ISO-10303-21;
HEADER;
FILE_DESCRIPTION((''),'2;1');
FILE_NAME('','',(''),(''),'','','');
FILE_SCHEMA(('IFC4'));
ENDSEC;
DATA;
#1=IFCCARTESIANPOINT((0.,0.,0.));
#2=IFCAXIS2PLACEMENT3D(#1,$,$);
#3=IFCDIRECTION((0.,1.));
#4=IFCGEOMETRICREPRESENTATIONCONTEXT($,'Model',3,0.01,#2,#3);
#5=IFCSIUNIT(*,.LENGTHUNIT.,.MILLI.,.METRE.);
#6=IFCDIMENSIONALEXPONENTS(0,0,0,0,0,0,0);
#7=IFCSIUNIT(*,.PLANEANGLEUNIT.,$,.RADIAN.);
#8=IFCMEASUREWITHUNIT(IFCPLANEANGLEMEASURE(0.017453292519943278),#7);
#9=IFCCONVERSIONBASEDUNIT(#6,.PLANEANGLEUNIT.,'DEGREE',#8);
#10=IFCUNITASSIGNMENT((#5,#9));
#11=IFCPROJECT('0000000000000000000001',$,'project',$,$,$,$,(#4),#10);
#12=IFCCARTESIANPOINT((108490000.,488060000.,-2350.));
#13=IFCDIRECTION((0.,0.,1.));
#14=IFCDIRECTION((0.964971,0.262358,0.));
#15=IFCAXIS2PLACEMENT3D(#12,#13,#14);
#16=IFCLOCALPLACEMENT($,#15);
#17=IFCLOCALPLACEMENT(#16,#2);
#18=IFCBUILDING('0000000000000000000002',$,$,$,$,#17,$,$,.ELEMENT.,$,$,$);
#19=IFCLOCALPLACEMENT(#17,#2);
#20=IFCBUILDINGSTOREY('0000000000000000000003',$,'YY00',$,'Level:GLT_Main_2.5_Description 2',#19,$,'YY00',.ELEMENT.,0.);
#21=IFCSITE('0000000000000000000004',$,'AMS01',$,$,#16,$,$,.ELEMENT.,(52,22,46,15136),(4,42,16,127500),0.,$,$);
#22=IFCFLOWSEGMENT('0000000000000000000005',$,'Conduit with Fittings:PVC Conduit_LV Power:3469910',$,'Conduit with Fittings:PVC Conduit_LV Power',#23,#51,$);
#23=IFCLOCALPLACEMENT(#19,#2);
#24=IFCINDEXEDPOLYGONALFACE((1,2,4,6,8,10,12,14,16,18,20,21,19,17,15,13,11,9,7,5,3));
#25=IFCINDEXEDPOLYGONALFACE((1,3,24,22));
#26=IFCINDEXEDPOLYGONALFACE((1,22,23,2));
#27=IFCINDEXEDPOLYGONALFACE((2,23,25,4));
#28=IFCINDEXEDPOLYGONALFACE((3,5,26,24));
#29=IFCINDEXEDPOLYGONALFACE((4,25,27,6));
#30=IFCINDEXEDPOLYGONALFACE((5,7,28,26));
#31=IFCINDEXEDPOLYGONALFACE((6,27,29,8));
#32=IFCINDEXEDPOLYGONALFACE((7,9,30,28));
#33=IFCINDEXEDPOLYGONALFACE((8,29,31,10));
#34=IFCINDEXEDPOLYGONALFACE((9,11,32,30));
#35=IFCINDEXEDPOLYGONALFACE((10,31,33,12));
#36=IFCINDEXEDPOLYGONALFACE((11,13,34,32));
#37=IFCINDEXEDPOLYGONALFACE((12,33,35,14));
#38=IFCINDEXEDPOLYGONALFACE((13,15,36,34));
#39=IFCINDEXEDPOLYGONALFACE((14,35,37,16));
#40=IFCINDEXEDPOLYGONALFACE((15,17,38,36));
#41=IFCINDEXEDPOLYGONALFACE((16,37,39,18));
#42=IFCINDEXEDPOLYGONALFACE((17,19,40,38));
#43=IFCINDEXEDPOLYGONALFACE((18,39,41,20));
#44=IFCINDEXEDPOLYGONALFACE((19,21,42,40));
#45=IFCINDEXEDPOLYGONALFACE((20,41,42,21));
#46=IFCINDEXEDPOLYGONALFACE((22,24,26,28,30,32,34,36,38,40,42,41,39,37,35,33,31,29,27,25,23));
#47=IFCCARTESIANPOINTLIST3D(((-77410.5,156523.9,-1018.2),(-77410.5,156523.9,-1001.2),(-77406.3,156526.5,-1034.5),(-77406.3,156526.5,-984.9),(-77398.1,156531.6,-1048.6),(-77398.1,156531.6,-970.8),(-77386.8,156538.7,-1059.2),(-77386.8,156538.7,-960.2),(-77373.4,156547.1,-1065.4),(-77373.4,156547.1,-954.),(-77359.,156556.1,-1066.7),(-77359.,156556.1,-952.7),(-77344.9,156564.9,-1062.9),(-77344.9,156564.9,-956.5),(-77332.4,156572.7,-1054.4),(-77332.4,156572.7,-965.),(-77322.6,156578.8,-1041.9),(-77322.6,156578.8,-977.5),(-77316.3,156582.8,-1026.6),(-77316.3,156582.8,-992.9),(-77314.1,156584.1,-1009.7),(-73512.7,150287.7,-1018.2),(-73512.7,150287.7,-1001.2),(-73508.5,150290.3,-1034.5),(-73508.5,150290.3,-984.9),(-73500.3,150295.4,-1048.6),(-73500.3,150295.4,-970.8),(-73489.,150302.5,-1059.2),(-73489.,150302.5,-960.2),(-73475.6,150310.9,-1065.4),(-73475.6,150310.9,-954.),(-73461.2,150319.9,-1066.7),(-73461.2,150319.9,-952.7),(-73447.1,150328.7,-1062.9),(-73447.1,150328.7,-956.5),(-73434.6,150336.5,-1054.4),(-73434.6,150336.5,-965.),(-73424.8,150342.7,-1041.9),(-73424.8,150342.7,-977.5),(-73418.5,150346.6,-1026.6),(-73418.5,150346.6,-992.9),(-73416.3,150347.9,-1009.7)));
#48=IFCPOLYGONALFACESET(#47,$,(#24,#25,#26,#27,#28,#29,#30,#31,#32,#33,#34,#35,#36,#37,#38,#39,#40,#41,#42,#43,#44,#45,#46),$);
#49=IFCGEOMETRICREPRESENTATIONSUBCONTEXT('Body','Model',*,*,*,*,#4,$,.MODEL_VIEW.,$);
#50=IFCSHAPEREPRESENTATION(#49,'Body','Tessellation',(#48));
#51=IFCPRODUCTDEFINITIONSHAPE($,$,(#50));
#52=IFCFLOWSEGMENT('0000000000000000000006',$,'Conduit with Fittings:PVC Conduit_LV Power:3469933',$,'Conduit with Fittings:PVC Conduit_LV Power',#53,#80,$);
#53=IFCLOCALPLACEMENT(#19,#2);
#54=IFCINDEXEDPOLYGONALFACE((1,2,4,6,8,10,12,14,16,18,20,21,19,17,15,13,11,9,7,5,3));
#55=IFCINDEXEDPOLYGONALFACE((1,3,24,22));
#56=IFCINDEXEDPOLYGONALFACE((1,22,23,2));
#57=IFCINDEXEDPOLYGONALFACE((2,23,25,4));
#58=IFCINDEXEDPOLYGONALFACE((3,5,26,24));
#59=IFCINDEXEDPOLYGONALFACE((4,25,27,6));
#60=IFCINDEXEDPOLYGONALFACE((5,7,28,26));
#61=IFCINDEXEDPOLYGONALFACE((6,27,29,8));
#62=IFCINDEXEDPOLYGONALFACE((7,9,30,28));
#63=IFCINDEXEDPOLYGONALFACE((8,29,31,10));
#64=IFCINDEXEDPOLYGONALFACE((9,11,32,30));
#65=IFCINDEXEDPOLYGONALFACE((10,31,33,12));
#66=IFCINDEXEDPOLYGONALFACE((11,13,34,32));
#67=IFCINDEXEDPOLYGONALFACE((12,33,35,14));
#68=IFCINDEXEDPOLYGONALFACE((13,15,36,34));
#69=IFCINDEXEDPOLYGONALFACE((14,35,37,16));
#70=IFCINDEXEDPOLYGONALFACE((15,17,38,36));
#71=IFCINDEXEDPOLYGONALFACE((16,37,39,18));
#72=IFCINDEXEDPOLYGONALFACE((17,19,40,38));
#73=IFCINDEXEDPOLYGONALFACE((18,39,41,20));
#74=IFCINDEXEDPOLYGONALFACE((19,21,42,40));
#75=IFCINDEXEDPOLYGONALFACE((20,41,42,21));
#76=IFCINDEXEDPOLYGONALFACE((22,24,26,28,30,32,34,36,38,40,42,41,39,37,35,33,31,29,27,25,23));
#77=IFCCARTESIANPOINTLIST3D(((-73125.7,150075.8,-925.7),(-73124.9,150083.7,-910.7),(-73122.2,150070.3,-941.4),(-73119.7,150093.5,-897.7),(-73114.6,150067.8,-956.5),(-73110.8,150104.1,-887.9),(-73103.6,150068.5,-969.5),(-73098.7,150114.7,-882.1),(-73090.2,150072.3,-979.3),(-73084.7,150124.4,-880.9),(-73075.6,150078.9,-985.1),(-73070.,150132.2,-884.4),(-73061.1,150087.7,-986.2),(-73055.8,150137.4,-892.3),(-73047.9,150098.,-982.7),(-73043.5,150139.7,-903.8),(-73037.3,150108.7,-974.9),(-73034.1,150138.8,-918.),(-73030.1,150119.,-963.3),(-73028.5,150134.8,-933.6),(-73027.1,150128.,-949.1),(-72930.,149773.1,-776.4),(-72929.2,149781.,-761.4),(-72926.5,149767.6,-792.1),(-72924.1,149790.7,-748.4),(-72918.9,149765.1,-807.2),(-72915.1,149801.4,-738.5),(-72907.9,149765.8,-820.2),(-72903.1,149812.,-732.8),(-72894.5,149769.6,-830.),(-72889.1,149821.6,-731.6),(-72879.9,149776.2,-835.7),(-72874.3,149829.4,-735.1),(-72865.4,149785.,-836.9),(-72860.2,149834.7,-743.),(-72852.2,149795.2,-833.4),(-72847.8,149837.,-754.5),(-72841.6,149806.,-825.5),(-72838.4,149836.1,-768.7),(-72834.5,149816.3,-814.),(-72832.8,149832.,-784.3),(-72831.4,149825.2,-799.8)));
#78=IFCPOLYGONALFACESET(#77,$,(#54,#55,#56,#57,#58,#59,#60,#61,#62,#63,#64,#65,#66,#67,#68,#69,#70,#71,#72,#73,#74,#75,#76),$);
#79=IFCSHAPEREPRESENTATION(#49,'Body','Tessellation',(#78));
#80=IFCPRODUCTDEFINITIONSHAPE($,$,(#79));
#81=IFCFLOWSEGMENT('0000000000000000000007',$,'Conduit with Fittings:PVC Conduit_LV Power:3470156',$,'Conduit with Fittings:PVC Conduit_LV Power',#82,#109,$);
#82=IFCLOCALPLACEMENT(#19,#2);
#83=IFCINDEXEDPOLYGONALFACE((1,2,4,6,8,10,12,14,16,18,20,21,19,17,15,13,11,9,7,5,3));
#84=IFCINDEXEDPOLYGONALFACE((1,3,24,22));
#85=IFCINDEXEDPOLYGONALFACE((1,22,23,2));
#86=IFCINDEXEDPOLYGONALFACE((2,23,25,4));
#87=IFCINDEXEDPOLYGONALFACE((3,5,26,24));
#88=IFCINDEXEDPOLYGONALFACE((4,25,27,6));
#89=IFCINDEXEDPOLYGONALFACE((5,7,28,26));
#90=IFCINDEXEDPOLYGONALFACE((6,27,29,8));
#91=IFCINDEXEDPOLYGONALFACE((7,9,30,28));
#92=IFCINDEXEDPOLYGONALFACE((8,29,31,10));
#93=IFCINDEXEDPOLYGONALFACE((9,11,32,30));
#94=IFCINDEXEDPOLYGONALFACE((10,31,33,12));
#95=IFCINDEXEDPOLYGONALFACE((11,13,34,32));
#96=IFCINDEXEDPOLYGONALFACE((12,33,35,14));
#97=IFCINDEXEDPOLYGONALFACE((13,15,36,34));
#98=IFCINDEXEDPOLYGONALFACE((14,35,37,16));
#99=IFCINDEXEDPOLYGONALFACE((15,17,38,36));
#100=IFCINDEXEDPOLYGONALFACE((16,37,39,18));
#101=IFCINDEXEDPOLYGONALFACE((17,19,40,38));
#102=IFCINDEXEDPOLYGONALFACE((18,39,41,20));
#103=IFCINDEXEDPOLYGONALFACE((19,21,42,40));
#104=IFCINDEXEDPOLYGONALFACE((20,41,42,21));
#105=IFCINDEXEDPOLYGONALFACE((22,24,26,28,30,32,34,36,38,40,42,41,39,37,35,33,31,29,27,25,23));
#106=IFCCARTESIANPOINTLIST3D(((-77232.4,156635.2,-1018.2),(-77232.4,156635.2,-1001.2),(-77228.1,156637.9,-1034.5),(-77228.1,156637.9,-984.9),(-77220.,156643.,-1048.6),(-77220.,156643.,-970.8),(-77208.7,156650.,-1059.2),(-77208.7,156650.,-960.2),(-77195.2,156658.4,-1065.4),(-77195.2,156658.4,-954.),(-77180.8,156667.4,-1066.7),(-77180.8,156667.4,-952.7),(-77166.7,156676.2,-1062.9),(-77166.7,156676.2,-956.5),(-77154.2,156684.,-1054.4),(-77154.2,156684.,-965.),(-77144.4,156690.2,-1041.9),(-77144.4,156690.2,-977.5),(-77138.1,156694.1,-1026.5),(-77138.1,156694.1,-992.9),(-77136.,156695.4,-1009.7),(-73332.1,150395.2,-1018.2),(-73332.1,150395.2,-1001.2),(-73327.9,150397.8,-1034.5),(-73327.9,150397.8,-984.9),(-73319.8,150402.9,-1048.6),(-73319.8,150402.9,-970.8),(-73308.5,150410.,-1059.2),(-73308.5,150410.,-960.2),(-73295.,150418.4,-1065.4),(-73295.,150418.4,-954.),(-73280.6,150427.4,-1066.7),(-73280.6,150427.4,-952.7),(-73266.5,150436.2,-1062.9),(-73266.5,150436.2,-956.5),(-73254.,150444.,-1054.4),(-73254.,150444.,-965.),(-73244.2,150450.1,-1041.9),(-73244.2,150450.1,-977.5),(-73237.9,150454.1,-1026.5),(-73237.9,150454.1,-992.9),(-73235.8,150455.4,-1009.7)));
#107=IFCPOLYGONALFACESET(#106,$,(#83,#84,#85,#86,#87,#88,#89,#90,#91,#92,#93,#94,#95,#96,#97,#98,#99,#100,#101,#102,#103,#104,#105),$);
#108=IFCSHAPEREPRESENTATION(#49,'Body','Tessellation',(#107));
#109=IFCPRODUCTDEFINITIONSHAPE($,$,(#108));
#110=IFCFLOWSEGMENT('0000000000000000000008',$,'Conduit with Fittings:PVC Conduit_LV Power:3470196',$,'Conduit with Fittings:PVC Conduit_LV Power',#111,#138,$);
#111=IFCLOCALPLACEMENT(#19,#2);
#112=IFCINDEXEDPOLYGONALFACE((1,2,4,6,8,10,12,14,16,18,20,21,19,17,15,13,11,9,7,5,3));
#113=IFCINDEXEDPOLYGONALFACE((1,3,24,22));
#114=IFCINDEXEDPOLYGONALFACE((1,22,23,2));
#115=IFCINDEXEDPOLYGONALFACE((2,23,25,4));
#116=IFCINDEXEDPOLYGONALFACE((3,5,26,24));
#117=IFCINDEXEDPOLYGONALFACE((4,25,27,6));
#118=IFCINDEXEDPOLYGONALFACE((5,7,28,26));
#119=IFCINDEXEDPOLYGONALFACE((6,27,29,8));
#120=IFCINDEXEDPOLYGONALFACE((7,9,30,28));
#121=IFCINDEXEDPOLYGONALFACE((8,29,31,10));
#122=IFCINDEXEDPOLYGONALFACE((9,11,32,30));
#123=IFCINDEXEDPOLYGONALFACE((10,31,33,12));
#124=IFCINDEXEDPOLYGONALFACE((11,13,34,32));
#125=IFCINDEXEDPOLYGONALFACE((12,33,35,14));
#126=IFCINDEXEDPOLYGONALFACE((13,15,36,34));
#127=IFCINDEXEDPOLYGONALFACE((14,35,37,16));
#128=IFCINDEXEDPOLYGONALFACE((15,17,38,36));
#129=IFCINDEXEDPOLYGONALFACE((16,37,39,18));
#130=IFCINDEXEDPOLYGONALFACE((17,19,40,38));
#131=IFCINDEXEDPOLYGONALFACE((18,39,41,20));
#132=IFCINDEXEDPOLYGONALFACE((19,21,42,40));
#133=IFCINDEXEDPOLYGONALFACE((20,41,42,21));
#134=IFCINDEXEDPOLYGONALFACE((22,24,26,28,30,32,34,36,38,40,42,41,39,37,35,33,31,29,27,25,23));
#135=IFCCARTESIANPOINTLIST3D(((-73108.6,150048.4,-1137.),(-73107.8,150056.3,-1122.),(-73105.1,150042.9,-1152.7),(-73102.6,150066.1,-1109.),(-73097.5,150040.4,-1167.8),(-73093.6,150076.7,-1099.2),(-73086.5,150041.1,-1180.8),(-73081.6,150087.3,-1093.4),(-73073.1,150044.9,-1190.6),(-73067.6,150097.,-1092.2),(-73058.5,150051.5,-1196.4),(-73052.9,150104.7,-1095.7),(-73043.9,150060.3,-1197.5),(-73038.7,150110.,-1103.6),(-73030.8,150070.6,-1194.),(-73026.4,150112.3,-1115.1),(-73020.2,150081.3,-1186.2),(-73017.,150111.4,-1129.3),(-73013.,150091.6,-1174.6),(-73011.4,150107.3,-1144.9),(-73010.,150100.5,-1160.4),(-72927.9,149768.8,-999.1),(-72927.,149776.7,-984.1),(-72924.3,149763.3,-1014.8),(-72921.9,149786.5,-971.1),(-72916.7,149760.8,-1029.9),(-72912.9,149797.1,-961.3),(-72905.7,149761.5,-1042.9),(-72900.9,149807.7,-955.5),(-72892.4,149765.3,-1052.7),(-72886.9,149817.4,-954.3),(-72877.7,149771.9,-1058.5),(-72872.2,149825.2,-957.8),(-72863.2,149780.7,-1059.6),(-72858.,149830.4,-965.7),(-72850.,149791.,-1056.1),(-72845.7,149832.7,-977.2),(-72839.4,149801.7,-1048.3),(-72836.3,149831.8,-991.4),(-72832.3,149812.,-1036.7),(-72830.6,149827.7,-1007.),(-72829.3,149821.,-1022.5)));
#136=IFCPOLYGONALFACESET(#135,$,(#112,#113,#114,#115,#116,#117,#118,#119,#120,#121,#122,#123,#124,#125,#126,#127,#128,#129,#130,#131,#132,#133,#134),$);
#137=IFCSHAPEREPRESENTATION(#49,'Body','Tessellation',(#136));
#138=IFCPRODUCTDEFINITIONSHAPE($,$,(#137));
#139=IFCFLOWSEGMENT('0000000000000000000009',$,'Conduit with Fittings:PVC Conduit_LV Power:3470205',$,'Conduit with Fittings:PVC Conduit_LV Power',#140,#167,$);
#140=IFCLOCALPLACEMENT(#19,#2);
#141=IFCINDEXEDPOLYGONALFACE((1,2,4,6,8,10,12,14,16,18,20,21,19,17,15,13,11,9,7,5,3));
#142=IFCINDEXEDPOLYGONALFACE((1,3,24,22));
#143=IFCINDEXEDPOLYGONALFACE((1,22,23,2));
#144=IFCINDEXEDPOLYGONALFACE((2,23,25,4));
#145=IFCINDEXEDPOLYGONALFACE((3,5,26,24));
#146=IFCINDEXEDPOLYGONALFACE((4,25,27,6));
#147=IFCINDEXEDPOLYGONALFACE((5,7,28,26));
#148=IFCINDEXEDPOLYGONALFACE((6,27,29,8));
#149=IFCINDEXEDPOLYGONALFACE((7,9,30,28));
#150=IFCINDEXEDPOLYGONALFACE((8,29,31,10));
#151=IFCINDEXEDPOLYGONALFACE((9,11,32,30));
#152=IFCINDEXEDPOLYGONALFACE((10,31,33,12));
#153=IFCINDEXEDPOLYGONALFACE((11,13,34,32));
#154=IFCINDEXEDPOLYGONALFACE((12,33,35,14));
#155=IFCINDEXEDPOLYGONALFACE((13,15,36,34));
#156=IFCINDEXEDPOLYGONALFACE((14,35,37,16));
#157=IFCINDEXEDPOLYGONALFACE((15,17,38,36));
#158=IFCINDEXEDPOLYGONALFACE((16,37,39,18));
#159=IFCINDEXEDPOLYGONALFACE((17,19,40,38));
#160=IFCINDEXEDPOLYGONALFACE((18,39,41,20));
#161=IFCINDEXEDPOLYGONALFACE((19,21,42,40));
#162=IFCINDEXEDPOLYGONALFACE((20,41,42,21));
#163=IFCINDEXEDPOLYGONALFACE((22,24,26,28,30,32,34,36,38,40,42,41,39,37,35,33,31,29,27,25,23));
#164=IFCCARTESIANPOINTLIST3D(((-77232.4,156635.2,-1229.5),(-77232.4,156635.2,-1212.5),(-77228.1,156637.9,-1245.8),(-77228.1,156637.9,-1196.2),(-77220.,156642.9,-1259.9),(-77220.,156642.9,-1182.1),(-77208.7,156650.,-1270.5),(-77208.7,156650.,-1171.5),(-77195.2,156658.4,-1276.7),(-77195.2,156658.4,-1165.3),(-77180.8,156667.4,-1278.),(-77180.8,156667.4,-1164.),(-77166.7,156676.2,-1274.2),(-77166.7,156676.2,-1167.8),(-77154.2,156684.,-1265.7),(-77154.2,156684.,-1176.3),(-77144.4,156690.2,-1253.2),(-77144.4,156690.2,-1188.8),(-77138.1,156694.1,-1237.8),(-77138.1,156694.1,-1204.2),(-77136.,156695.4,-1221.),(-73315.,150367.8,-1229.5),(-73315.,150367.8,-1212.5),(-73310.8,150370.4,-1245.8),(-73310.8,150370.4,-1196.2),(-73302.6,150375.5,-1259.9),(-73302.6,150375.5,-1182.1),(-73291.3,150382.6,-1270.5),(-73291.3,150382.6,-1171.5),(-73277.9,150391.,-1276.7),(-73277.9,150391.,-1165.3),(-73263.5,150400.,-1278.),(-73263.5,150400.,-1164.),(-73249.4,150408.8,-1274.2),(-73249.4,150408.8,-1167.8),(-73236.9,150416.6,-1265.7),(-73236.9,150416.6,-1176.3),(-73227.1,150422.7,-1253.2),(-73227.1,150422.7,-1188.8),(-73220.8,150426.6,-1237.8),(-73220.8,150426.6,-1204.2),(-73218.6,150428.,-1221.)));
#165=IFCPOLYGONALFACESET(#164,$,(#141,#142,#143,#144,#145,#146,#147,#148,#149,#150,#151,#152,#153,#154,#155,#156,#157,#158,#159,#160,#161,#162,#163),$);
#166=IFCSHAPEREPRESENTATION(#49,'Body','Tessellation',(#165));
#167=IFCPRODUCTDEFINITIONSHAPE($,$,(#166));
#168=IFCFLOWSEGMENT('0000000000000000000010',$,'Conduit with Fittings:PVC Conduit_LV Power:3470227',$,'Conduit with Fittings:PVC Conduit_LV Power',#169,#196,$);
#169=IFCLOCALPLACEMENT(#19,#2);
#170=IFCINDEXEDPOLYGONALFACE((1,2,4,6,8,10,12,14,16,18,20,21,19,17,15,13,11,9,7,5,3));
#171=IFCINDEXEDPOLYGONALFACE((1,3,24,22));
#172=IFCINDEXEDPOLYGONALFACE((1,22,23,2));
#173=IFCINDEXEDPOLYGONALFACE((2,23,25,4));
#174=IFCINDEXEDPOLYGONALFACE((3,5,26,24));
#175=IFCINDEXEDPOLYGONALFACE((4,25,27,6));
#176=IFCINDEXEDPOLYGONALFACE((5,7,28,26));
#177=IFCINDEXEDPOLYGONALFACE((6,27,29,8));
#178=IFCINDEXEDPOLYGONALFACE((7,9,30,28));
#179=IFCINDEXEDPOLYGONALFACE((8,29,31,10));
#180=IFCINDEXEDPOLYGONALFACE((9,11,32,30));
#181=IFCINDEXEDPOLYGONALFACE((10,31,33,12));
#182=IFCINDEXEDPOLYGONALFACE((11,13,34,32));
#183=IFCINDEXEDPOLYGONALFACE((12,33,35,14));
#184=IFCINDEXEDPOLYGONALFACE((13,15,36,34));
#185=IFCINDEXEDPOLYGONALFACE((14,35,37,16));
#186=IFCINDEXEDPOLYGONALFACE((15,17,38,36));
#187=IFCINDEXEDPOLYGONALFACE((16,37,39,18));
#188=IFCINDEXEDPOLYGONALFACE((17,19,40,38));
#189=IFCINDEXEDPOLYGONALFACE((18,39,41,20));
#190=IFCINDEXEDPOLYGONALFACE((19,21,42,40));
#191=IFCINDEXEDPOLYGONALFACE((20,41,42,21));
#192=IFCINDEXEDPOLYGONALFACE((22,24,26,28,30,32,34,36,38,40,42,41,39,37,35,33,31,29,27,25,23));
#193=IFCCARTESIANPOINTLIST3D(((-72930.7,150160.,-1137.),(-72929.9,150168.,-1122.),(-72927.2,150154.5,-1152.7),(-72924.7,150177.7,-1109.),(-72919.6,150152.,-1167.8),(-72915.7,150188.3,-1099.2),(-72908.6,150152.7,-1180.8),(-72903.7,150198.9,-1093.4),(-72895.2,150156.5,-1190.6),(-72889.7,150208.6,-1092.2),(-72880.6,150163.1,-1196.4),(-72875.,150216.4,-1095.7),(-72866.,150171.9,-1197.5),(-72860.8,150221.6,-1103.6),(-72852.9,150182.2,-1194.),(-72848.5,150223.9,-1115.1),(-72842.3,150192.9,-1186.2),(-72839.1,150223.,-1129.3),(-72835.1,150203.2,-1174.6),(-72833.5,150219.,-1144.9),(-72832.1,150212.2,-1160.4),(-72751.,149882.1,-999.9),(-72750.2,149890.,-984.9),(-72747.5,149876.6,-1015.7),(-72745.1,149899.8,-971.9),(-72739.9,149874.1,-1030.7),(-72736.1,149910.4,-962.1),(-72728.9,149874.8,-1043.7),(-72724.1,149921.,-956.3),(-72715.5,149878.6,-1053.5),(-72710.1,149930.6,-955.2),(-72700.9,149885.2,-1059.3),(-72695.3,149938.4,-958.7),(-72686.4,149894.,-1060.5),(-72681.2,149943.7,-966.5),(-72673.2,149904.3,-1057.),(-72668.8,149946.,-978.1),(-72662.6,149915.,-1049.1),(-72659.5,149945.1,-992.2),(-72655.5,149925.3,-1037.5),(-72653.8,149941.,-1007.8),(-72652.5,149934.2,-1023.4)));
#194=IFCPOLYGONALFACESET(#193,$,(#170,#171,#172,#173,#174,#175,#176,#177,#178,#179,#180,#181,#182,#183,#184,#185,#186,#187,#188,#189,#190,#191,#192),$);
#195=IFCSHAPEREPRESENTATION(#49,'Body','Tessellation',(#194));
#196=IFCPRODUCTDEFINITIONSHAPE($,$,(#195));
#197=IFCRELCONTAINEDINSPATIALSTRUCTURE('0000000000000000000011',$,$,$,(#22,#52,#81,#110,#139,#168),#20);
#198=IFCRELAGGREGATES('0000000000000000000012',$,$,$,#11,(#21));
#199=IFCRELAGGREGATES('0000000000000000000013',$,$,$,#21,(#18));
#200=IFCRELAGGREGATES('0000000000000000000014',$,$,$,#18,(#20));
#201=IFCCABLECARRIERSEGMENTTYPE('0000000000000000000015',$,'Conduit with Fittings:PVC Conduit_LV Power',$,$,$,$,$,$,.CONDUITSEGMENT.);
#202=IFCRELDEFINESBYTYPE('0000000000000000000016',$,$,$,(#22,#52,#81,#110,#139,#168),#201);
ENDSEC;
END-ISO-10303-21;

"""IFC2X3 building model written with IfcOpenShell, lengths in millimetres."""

from ifc_helpers import new_model, entity, si_unit, converted_unit, direction, frame, frame_2d, origin, origin_2d_with_axis, place, context, subcontext, project, spatial, circle, extrude, type_object, element, save


model = new_model("IFC2X3")

# Units and contexts
model_context = context("Model", 3, precision=0.01, world=origin(), true_north=direction((0.0, 1.0)))
body_context = subcontext(model_context, "Body", "Model", "MODEL_VIEW")
ifc_project = project(units=[si_unit("LENGTHUNIT", "METRE", prefix="MILLI"), converted_unit("PLANEANGLEUNIT", "DEGREE", entity("IfcPlaneAngleMeasure", 0.017453292519943278), si_unit("PLANEANGLEUNIT", "RADIAN"), dimensions=[0, 0, 0, 0, 0, 0, 0])], contexts=[model_context])

# Site, building, storey
site_placement = place(None, frame((108490000.0, 488060000.0, -2350.0), z_axis=(0.0, 0.0, 1.0), x_axis=(0.964971, 0.262358, 0.0)))
site = spatial("IfcSite", under=ifc_project, at=site_placement, Name="AMS01", CompositionType="ELEMENT", RefLatitude=(52, 22, 46, 15136), RefLongitude=(4, 42, 16, 127500), RefElevation=0.0)
building_placement = place(site_placement, origin())
building = spatial("IfcBuilding", under=site, at=building_placement, CompositionType="ELEMENT")
storey_placement = place(building_placement, origin())
storey = spatial("IfcBuildingStorey", under=building, at=storey_placement, Name="YY00", ObjectType="Level:GLT_Main_2.5_Description 2", LongName="YY00", CompositionType="ELEMENT", Elevation=0.0)

# Flow segments
cable_carrier_segment_type = type_object("IfcCableCarrierSegmentType", Name="Conduit with Fittings:PVC Conduit_LV Power", PredefinedType="CONDUITSEGMENT")
flow_segment_1_placement = place(storey_placement, origin())
element("IfcFlowSegment", 1, at=flow_segment_1_placement, inside=storey, type_object=cable_carrier_segment_type, Name="Conduit with Fittings:PVC Conduit_LV Power:3469910", ObjectType="Conduit with Fittings:PVC Conduit_LV Power", context=body_context, shape_type="SweptSolid", body=[
    extrude(circle(Radius=57.2, at=origin_2d_with_axis()), frame((-77362.6, 156553.8, -1009.7), z_axis=(0.530017, -0.847987, 0.0), x_axis=(0.847987, 0.530017, 0.0)), (0.0, 0.0, 1.0), 7354.1),
])
flow_segment_2_placement = place(storey_placement, origin())
element("IfcFlowSegment", 2, at=flow_segment_2_placement, inside=storey, type_object=cable_carrier_segment_type, Name="Conduit with Fittings:PVC Conduit_LV Power:3469933", ObjectType="Conduit with Fittings:PVC Conduit_LV Power", context=body_context, shape_type="SweptSolid", body=[
    extrude(circle(Radius=57.2, at=frame_2d((0.0, 0.0), x_axis=(1.0, 0.0))), frame((-73076.5, 150103.7, -933.6), z_axis=(0.501534, -0.775898, 0.382683), x_axis=(0.839826, 0.542856, 0.0)), (0.0, 0.0, 1.0), 390.2),
])
flow_segment_3_placement = place(storey_placement, origin())
element("IfcFlowSegment", 3, at=flow_segment_3_placement, inside=storey, type_object=cable_carrier_segment_type, Name="Conduit with Fittings:PVC Conduit_LV Power:3470156", ObjectType="Conduit with Fittings:PVC Conduit_LV Power", context=body_context, shape_type="SweptSolid", body=[
    extrude(circle(Radius=57.2, at=origin_2d_with_axis()), frame((-77184.4, 156665.2, -1009.7), z_axis=(0.530017, -0.847987, 0.0), x_axis=(0.847987, 0.530017, 0.0)), (0.0, 0.0, 1.0), 7358.7),
])
flow_segment_4_placement = place(storey_placement, origin())
element("IfcFlowSegment", 4, at=flow_segment_4_placement, inside=storey, type_object=cable_carrier_segment_type, Name="Conduit with Fittings:PVC Conduit_LV Power:3470196", ObjectType="Conduit with Fittings:PVC Conduit_LV Power", context=body_context, shape_type="SweptSolid", body=[
    extrude(circle(Radius=57.2, at=frame_2d((0.0, 0.0), x_axis=(1.0, 0.0))), frame((-73059.4, 150076.3, -1144.9), z_axis=(0.501534, -0.775898, 0.382683), x_axis=(0.839826, 0.542856, 0.0)), (0.0, 0.0, 1.0), 360.4),
])
flow_segment_5_placement = place(storey_placement, origin())
element("IfcFlowSegment", 5, at=flow_segment_5_placement, inside=storey, type_object=cable_carrier_segment_type, Name="Conduit with Fittings:PVC Conduit_LV Power:3470205", ObjectType="Conduit with Fittings:PVC Conduit_LV Power", context=body_context, shape_type="SweptSolid", body=[
    extrude(circle(Radius=57.2, at=origin_2d_with_axis()), frame((-77184.4, 156665.2, -1221.0), z_axis=(0.530017, -0.847987, 0.0), x_axis=(0.847987, 0.530017, 0.0)), (0.0, 0.0, 1.0), 7391.0),
])
flow_segment_6_placement = place(storey_placement, origin())
element("IfcFlowSegment", 6, at=flow_segment_6_placement, inside=storey, type_object=cable_carrier_segment_type, Name="Conduit with Fittings:PVC Conduit_LV Power:3470227", ObjectType="Conduit with Fittings:PVC Conduit_LV Power", context=body_context, shape_type="SweptSolid", body=[
    extrude(circle(Radius=57.2, at=frame_2d((0.0, 0.0), x_axis=(1.0, 0.0))), frame((-72701.8, 149910.0, -1007.8), z_axis=(-0.501534, 0.775898, -0.382683), x_axis=(0.839826, 0.542856, 0.0)), (0.0, 0.0, 1.0), 358.2),
])

save(model, "model.ifc")
